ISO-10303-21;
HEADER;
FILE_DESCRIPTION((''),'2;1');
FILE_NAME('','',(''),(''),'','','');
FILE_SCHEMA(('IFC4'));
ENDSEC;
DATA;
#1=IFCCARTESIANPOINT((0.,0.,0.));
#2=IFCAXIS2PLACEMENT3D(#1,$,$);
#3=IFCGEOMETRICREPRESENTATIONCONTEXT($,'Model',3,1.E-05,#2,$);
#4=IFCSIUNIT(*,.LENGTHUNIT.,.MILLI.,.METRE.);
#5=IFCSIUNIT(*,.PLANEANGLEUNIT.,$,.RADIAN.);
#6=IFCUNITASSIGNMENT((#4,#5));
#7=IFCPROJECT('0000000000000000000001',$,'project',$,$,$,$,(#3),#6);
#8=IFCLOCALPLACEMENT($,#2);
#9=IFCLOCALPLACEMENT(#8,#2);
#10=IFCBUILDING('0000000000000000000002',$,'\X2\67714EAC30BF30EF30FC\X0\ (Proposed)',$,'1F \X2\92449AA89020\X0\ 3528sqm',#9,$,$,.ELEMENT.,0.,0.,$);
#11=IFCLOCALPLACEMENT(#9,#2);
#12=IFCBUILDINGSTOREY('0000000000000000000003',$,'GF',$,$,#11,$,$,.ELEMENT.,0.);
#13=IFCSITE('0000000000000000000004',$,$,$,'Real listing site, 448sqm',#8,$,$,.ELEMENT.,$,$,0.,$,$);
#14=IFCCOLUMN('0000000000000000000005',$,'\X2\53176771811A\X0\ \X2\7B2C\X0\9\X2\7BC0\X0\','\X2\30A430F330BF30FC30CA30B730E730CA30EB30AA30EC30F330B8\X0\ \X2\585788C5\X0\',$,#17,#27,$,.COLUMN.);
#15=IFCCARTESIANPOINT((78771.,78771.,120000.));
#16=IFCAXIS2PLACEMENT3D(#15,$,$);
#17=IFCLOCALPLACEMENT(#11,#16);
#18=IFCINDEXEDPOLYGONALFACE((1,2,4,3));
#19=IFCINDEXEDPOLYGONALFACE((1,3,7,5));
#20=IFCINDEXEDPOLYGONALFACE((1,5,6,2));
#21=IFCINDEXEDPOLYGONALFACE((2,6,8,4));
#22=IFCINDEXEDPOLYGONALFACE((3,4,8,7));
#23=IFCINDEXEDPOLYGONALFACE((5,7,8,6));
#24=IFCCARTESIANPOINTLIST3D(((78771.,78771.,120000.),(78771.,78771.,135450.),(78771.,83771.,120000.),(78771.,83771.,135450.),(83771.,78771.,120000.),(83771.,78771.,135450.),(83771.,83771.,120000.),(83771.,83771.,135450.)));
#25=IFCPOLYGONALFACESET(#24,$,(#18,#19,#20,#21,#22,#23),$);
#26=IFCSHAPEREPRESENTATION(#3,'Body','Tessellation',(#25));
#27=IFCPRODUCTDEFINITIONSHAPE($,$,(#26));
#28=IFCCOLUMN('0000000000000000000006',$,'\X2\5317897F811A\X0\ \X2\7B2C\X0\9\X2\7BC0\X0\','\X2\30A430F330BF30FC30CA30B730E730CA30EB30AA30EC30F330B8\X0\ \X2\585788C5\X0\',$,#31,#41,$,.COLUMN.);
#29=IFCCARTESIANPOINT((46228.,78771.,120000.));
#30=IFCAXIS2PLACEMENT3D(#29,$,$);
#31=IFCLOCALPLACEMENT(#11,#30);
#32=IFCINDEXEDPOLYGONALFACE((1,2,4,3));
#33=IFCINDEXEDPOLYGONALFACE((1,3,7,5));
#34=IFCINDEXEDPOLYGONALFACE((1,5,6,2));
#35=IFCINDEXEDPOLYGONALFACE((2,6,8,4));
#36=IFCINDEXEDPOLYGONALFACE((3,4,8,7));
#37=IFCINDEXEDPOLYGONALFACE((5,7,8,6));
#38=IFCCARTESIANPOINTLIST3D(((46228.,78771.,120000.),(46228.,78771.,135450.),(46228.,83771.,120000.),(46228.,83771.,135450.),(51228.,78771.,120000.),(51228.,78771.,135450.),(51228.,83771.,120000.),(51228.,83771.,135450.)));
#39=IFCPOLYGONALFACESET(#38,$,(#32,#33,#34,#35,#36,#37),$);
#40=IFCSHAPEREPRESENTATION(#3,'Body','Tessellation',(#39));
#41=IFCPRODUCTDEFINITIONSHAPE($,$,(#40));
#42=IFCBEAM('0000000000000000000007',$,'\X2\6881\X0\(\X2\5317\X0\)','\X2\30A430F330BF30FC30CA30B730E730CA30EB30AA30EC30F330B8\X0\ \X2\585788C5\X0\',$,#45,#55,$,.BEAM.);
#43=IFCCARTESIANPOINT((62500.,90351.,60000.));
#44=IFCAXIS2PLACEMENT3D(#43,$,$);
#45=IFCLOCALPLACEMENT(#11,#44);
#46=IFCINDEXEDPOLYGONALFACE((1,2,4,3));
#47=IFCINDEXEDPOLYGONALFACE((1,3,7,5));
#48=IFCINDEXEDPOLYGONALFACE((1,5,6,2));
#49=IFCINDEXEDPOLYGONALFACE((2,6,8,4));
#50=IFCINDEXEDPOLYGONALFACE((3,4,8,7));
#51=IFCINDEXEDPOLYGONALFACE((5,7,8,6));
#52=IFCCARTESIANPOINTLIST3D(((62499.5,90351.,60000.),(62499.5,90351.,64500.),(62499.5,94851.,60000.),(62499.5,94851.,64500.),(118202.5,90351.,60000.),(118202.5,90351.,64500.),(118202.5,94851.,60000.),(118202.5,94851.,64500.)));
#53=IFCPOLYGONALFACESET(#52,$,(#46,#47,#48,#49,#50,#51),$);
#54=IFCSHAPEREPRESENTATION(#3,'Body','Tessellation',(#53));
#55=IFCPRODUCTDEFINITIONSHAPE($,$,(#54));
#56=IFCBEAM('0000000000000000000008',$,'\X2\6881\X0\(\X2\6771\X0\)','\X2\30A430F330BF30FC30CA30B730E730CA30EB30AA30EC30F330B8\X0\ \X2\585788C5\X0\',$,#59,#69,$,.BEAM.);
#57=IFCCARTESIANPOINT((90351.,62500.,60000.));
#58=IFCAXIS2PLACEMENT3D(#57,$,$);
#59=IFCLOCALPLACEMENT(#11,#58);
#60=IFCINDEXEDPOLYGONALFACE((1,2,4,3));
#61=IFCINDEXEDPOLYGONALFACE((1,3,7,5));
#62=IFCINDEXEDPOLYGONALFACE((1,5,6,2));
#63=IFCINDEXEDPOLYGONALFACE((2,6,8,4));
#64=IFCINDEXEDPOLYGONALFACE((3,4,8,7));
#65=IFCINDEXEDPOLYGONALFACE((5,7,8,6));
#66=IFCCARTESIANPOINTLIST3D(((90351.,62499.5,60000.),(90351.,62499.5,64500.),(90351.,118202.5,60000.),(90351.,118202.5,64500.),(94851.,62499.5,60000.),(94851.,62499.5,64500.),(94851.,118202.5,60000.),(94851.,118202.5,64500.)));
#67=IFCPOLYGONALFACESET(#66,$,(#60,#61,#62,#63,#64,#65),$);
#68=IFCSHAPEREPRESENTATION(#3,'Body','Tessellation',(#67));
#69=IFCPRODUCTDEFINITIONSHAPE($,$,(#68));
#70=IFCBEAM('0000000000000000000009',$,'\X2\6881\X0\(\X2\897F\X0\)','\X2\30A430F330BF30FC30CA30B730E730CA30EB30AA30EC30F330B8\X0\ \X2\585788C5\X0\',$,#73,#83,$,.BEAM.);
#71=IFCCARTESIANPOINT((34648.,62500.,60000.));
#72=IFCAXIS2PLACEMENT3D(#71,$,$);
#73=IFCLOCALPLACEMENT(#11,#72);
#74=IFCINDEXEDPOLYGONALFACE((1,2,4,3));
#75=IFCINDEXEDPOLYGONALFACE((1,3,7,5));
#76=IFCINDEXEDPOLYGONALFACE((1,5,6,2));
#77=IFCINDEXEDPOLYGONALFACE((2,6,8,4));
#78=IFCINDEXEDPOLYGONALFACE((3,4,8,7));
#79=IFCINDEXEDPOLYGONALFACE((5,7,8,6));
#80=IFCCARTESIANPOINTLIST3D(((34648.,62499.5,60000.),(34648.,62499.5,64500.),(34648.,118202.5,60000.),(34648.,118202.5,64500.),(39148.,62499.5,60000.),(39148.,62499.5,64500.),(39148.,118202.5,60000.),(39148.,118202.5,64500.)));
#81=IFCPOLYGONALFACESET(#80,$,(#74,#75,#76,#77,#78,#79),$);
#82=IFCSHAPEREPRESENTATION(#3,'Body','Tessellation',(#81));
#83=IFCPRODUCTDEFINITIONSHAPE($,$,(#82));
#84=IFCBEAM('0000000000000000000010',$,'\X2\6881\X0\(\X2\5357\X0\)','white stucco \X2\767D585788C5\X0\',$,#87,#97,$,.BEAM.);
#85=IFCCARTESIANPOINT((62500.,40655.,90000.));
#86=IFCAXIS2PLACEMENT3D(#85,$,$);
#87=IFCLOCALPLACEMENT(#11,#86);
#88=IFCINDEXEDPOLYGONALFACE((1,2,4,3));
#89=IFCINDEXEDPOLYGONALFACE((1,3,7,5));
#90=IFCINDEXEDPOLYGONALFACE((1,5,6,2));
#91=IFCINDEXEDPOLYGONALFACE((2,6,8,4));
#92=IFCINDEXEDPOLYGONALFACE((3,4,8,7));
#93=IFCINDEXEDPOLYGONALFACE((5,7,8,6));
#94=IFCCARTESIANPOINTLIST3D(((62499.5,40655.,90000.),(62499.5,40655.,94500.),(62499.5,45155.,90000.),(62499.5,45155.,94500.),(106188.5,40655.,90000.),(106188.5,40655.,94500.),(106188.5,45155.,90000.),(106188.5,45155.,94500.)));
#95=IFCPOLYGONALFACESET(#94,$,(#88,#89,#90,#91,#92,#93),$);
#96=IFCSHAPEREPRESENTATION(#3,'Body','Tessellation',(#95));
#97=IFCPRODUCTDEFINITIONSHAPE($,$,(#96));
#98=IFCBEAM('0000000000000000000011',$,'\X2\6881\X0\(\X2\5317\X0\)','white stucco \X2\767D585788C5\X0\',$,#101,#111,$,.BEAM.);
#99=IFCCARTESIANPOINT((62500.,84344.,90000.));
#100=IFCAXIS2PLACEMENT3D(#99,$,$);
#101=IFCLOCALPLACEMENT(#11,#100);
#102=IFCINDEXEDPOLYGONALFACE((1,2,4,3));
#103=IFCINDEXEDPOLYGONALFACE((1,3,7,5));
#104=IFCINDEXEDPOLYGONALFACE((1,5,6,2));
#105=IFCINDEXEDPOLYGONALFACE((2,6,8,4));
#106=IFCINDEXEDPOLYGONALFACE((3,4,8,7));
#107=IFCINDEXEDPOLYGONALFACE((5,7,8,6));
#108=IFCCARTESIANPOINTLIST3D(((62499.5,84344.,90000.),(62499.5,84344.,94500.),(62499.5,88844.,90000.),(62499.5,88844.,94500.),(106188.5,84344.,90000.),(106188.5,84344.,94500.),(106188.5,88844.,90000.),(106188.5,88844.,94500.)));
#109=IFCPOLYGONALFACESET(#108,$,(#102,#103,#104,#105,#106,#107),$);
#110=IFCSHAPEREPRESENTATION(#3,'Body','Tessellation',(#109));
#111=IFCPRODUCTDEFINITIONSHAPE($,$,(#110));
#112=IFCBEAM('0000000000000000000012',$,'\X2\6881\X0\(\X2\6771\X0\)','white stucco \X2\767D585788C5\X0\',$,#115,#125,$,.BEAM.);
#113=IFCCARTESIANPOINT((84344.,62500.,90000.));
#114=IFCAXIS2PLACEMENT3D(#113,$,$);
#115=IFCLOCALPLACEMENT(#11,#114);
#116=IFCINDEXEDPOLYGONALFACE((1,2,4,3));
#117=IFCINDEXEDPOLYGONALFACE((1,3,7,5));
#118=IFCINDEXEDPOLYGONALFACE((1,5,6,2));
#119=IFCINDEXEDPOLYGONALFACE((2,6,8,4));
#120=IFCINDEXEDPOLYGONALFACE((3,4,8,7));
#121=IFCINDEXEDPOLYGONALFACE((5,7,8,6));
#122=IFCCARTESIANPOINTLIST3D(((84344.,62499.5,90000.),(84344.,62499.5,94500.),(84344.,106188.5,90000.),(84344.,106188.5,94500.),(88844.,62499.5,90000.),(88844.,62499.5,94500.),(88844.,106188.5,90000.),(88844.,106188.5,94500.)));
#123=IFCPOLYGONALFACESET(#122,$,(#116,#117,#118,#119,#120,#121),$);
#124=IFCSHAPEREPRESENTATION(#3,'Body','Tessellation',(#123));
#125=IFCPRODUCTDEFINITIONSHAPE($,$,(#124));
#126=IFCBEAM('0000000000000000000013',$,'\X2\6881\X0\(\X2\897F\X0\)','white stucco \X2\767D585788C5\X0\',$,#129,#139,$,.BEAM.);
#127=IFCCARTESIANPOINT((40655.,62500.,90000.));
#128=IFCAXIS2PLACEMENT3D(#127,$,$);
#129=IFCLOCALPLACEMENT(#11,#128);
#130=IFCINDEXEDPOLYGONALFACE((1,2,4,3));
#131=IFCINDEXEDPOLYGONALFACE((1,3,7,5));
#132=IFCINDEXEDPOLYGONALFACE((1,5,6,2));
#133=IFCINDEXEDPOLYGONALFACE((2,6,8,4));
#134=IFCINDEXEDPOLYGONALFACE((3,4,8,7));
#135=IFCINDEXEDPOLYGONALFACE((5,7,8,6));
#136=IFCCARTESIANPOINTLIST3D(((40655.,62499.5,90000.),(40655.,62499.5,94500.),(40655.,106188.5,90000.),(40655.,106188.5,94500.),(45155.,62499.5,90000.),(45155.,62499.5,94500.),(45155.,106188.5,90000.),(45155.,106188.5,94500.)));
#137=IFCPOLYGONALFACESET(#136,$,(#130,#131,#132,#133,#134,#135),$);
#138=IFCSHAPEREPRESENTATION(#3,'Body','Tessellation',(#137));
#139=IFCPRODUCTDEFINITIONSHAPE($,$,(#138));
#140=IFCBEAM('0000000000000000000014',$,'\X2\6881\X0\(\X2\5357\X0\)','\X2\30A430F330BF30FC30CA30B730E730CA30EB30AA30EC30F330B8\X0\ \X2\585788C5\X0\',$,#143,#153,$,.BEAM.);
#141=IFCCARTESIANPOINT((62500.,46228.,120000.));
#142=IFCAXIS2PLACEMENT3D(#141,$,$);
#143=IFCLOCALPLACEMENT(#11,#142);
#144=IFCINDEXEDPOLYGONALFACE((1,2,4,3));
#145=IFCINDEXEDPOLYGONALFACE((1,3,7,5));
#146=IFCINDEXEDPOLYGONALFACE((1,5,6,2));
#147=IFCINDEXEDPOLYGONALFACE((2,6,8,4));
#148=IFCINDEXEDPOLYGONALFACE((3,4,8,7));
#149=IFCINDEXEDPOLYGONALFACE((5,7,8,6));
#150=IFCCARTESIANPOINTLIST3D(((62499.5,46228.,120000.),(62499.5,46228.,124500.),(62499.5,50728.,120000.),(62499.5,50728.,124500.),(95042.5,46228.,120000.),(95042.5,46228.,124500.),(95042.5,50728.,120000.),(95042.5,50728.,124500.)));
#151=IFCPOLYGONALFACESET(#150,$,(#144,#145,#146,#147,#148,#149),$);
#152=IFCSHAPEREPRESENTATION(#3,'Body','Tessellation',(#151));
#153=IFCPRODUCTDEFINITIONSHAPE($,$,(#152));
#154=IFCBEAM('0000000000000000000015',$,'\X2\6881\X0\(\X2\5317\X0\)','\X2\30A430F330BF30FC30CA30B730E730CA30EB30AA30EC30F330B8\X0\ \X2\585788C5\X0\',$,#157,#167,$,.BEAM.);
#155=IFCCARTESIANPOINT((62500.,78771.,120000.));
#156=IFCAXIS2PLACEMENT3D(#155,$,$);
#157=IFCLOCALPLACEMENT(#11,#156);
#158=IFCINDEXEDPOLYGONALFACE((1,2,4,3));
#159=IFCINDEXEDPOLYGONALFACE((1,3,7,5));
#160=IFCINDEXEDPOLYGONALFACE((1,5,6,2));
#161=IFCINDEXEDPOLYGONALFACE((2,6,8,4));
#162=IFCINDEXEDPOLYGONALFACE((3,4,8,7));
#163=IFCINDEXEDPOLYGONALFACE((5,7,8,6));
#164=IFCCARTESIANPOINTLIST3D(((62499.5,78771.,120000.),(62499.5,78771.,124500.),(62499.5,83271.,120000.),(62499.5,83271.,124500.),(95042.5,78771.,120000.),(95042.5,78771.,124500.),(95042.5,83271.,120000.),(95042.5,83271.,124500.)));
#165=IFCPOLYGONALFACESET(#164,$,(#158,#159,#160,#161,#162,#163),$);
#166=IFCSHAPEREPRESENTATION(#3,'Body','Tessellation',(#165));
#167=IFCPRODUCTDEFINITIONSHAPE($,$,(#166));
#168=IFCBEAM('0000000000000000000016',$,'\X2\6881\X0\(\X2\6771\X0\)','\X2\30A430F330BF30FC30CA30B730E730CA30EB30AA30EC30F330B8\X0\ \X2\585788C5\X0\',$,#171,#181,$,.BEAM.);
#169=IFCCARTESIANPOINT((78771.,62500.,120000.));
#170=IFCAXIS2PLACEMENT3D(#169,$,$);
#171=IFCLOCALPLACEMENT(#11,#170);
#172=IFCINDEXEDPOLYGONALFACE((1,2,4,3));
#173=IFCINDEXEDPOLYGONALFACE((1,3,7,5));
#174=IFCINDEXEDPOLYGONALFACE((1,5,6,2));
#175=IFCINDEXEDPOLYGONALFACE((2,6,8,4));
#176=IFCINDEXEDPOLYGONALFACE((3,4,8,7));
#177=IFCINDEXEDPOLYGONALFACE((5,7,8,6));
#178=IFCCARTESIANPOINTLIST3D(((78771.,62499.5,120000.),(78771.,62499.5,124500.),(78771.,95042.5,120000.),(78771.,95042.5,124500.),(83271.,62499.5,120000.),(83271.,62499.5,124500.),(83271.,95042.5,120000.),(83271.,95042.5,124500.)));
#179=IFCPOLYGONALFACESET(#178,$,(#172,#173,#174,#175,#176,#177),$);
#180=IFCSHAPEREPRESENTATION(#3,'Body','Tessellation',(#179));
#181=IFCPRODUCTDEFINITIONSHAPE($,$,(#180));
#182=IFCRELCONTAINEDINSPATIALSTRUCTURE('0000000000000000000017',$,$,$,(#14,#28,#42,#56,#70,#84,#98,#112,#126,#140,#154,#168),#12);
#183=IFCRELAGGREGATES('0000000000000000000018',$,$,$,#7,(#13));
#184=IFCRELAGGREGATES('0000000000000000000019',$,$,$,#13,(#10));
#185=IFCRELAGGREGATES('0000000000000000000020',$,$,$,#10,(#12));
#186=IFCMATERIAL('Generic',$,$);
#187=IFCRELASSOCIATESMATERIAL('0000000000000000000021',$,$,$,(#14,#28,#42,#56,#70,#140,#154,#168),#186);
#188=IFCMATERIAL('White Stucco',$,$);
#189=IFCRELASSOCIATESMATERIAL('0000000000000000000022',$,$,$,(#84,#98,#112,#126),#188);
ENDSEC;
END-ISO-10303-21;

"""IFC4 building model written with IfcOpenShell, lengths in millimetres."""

from ifc_helpers import new_model, si_unit, frame, frame_2d, origin, place, context, project, spatial, rectangle, extrude, material, element, save


model = new_model("IFC4")

# Units and contexts
model_context = context("Model", 3, precision=1e-05, world=origin())
ifc_project = project(units=[si_unit("LENGTHUNIT", "METRE", prefix="MILLI"), si_unit("PLANEANGLEUNIT", "RADIAN")], contexts=[model_context])

# Site, building, storey
site_placement = place(None, origin())
site = spatial("IfcSite", under=ifc_project, at=site_placement, ObjectType="Real listing site, 448sqm", CompositionType="ELEMENT", RefElevation=0.0)
building_placement = place(site_placement, origin())
building = spatial("IfcBuilding", under=site, at=building_placement, Name="東京タワー (Proposed)", ObjectType="1F 鉄骨造 3528sqm", CompositionType="ELEMENT", ElevationOfRefHeight=0.0, ElevationOfTerrain=0.0)
storey_placement = place(building_placement, origin())
storey = spatial("IfcBuildingStorey", under=building, at=storey_placement, Name="GF", CompositionType="ELEMENT", Elevation=0.0)

# Columns
ifc_material_1 = material(Name="White Stucco")
ifc_material_2 = material(Name="Generic")
column_1_placement = place(storey_placement, frame((78771.0, 78771.0, 120000.0)))
element("IfcColumn", 1, at=column_1_placement, inside=storey, material=ifc_material_2, Name="北東脚 第9節", Description="インターナショナルオレンジ 塗装", PredefinedType="COLUMN", context=model_context, shape_type="SweptSolid", body=[
    extrude(rectangle(XDim=5000.0, YDim=5000.0, at=frame_2d((2500.0, 2500.0))), frame((78771.0, 78771.0, 120000.0)), (0.0, 0.0, 1.0), 15450.0),
])
column_2_placement = place(storey_placement, frame((46228.0, 78771.0, 120000.0)))
element("IfcColumn", 2, at=column_2_placement, inside=storey, material=ifc_material_2, Name="北西脚 第9節", Description="インターナショナルオレンジ 塗装", PredefinedType="COLUMN", context=model_context, shape_type="SweptSolid", body=[
    extrude(rectangle(XDim=5000.0, YDim=5000.0, at=frame_2d((2500.0, 2500.0))), frame((46228.0, 78771.0, 120000.0)), (0.0, 0.0, 1.0), 15450.0),
])

# Beams
beam_1_placement = place(storey_placement, frame((62500.0, 90351.0, 60000.0)))
element("IfcBeam", 3, at=beam_1_placement, inside=storey, material=ifc_material_2, Name="梁(北)", Description="インターナショナルオレンジ 塗装", PredefinedType="BEAM", context=model_context, shape_type="SweptSolid", body=[
    extrude(rectangle(XDim=55703.0, YDim=4500.0, at=frame_2d((27851.0, 2250.0))), frame((62500.0, 90351.0, 60000.0)), (0.0, 0.0, 1.0), 4500.0),
])
beam_2_placement = place(storey_placement, frame((90351.0, 62500.0, 60000.0)))
element("IfcBeam", 4, at=beam_2_placement, inside=storey, material=ifc_material_2, Name="梁(東)", Description="インターナショナルオレンジ 塗装", PredefinedType="BEAM", context=model_context, shape_type="SweptSolid", body=[
    extrude(rectangle(XDim=4500.0, YDim=55703.0, at=frame_2d((2250.0, 27851.0))), frame((90351.0, 62500.0, 60000.0)), (0.0, 0.0, 1.0), 4500.0),
])
beam_3_placement = place(storey_placement, frame((34648.0, 62500.0, 60000.0)))
element("IfcBeam", 5, at=beam_3_placement, inside=storey, material=ifc_material_2, Name="梁(西)", Description="インターナショナルオレンジ 塗装", PredefinedType="BEAM", context=model_context, shape_type="SweptSolid", body=[
    extrude(rectangle(XDim=4500.0, YDim=55703.0, at=frame_2d((2250.0, 27851.0))), frame((34648.0, 62500.0, 60000.0)), (0.0, 0.0, 1.0), 4500.0),
])
beam_4_placement = place(storey_placement, frame((62500.0, 40655.0, 90000.0)))
element("IfcBeam", 6, at=beam_4_placement, inside=storey, material=ifc_material_1, Name="梁(南)", Description="white stucco 白塗装", PredefinedType="BEAM", context=model_context, shape_type="SweptSolid", body=[
    extrude(rectangle(XDim=43689.0, YDim=4500.0, at=frame_2d((21844.0, 2250.0))), frame((62500.0, 40655.0, 90000.0)), (0.0, 0.0, 1.0), 4500.0),
])
beam_5_placement = place(storey_placement, frame((62500.0, 84344.0, 90000.0)))
element("IfcBeam", 7, at=beam_5_placement, inside=storey, material=ifc_material_1, Name="梁(北)", Description="white stucco 白塗装", PredefinedType="BEAM", context=model_context, shape_type="SweptSolid", body=[
    extrude(rectangle(XDim=43689.0, YDim=4500.0, at=frame_2d((21844.0, 2250.0))), frame((62500.0, 84344.0, 90000.0)), (0.0, 0.0, 1.0), 4500.0),
])
beam_6_placement = place(storey_placement, frame((84344.0, 62500.0, 90000.0)))
element("IfcBeam", 8, at=beam_6_placement, inside=storey, material=ifc_material_1, Name="梁(東)", Description="white stucco 白塗装", PredefinedType="BEAM", context=model_context, shape_type="SweptSolid", body=[
    extrude(rectangle(XDim=4500.0, YDim=43689.0, at=frame_2d((2250.0, 21844.0))), frame((84344.0, 62500.0, 90000.0)), (0.0, 0.0, 1.0), 4500.0),
])
beam_7_placement = place(storey_placement, frame((40655.0, 62500.0, 90000.0)))
element("IfcBeam", 9, at=beam_7_placement, inside=storey, material=ifc_material_1, Name="梁(西)", Description="white stucco 白塗装", PredefinedType="BEAM", context=model_context, shape_type="SweptSolid", body=[
    extrude(rectangle(XDim=4500.0, YDim=43689.0, at=frame_2d((2250.0, 21844.0))), frame((40655.0, 62500.0, 90000.0)), (0.0, 0.0, 1.0), 4500.0),
])
beam_8_placement = place(storey_placement, frame((62500.0, 46228.0, 120000.0)))
element("IfcBeam", 10, at=beam_8_placement, inside=storey, material=ifc_material_2, Name="梁(南)", Description="インターナショナルオレンジ 塗装", PredefinedType="BEAM", context=model_context, shape_type="SweptSolid", body=[
    extrude(rectangle(XDim=32543.0, YDim=4500.0, at=frame_2d((16271.0, 2250.0))), frame((62500.0, 46228.0, 120000.0)), (0.0, 0.0, 1.0), 4500.0),
])
beam_9_placement = place(storey_placement, frame((62500.0, 78771.0, 120000.0)))
element("IfcBeam", 11, at=beam_9_placement, inside=storey, material=ifc_material_2, Name="梁(北)", Description="インターナショナルオレンジ 塗装", PredefinedType="BEAM", context=model_context, shape_type="SweptSolid", body=[
    extrude(rectangle(XDim=32543.0, YDim=4500.0, at=frame_2d((16271.0, 2250.0))), frame((62500.0, 78771.0, 120000.0)), (0.0, 0.0, 1.0), 4500.0),
])
beam_10_placement = place(storey_placement, frame((78771.0, 62500.0, 120000.0)))
element("IfcBeam", 12, at=beam_10_placement, inside=storey, material=ifc_material_2, Name="梁(東)", Description="インターナショナルオレンジ 塗装", PredefinedType="BEAM", context=model_context, shape_type="SweptSolid", body=[
    extrude(rectangle(XDim=4500.0, YDim=32543.0, at=frame_2d((2250.0, 16271.0))), frame((78771.0, 62500.0, 120000.0)), (0.0, 0.0, 1.0), 4500.0),
])

save(model, "model.ifc")
